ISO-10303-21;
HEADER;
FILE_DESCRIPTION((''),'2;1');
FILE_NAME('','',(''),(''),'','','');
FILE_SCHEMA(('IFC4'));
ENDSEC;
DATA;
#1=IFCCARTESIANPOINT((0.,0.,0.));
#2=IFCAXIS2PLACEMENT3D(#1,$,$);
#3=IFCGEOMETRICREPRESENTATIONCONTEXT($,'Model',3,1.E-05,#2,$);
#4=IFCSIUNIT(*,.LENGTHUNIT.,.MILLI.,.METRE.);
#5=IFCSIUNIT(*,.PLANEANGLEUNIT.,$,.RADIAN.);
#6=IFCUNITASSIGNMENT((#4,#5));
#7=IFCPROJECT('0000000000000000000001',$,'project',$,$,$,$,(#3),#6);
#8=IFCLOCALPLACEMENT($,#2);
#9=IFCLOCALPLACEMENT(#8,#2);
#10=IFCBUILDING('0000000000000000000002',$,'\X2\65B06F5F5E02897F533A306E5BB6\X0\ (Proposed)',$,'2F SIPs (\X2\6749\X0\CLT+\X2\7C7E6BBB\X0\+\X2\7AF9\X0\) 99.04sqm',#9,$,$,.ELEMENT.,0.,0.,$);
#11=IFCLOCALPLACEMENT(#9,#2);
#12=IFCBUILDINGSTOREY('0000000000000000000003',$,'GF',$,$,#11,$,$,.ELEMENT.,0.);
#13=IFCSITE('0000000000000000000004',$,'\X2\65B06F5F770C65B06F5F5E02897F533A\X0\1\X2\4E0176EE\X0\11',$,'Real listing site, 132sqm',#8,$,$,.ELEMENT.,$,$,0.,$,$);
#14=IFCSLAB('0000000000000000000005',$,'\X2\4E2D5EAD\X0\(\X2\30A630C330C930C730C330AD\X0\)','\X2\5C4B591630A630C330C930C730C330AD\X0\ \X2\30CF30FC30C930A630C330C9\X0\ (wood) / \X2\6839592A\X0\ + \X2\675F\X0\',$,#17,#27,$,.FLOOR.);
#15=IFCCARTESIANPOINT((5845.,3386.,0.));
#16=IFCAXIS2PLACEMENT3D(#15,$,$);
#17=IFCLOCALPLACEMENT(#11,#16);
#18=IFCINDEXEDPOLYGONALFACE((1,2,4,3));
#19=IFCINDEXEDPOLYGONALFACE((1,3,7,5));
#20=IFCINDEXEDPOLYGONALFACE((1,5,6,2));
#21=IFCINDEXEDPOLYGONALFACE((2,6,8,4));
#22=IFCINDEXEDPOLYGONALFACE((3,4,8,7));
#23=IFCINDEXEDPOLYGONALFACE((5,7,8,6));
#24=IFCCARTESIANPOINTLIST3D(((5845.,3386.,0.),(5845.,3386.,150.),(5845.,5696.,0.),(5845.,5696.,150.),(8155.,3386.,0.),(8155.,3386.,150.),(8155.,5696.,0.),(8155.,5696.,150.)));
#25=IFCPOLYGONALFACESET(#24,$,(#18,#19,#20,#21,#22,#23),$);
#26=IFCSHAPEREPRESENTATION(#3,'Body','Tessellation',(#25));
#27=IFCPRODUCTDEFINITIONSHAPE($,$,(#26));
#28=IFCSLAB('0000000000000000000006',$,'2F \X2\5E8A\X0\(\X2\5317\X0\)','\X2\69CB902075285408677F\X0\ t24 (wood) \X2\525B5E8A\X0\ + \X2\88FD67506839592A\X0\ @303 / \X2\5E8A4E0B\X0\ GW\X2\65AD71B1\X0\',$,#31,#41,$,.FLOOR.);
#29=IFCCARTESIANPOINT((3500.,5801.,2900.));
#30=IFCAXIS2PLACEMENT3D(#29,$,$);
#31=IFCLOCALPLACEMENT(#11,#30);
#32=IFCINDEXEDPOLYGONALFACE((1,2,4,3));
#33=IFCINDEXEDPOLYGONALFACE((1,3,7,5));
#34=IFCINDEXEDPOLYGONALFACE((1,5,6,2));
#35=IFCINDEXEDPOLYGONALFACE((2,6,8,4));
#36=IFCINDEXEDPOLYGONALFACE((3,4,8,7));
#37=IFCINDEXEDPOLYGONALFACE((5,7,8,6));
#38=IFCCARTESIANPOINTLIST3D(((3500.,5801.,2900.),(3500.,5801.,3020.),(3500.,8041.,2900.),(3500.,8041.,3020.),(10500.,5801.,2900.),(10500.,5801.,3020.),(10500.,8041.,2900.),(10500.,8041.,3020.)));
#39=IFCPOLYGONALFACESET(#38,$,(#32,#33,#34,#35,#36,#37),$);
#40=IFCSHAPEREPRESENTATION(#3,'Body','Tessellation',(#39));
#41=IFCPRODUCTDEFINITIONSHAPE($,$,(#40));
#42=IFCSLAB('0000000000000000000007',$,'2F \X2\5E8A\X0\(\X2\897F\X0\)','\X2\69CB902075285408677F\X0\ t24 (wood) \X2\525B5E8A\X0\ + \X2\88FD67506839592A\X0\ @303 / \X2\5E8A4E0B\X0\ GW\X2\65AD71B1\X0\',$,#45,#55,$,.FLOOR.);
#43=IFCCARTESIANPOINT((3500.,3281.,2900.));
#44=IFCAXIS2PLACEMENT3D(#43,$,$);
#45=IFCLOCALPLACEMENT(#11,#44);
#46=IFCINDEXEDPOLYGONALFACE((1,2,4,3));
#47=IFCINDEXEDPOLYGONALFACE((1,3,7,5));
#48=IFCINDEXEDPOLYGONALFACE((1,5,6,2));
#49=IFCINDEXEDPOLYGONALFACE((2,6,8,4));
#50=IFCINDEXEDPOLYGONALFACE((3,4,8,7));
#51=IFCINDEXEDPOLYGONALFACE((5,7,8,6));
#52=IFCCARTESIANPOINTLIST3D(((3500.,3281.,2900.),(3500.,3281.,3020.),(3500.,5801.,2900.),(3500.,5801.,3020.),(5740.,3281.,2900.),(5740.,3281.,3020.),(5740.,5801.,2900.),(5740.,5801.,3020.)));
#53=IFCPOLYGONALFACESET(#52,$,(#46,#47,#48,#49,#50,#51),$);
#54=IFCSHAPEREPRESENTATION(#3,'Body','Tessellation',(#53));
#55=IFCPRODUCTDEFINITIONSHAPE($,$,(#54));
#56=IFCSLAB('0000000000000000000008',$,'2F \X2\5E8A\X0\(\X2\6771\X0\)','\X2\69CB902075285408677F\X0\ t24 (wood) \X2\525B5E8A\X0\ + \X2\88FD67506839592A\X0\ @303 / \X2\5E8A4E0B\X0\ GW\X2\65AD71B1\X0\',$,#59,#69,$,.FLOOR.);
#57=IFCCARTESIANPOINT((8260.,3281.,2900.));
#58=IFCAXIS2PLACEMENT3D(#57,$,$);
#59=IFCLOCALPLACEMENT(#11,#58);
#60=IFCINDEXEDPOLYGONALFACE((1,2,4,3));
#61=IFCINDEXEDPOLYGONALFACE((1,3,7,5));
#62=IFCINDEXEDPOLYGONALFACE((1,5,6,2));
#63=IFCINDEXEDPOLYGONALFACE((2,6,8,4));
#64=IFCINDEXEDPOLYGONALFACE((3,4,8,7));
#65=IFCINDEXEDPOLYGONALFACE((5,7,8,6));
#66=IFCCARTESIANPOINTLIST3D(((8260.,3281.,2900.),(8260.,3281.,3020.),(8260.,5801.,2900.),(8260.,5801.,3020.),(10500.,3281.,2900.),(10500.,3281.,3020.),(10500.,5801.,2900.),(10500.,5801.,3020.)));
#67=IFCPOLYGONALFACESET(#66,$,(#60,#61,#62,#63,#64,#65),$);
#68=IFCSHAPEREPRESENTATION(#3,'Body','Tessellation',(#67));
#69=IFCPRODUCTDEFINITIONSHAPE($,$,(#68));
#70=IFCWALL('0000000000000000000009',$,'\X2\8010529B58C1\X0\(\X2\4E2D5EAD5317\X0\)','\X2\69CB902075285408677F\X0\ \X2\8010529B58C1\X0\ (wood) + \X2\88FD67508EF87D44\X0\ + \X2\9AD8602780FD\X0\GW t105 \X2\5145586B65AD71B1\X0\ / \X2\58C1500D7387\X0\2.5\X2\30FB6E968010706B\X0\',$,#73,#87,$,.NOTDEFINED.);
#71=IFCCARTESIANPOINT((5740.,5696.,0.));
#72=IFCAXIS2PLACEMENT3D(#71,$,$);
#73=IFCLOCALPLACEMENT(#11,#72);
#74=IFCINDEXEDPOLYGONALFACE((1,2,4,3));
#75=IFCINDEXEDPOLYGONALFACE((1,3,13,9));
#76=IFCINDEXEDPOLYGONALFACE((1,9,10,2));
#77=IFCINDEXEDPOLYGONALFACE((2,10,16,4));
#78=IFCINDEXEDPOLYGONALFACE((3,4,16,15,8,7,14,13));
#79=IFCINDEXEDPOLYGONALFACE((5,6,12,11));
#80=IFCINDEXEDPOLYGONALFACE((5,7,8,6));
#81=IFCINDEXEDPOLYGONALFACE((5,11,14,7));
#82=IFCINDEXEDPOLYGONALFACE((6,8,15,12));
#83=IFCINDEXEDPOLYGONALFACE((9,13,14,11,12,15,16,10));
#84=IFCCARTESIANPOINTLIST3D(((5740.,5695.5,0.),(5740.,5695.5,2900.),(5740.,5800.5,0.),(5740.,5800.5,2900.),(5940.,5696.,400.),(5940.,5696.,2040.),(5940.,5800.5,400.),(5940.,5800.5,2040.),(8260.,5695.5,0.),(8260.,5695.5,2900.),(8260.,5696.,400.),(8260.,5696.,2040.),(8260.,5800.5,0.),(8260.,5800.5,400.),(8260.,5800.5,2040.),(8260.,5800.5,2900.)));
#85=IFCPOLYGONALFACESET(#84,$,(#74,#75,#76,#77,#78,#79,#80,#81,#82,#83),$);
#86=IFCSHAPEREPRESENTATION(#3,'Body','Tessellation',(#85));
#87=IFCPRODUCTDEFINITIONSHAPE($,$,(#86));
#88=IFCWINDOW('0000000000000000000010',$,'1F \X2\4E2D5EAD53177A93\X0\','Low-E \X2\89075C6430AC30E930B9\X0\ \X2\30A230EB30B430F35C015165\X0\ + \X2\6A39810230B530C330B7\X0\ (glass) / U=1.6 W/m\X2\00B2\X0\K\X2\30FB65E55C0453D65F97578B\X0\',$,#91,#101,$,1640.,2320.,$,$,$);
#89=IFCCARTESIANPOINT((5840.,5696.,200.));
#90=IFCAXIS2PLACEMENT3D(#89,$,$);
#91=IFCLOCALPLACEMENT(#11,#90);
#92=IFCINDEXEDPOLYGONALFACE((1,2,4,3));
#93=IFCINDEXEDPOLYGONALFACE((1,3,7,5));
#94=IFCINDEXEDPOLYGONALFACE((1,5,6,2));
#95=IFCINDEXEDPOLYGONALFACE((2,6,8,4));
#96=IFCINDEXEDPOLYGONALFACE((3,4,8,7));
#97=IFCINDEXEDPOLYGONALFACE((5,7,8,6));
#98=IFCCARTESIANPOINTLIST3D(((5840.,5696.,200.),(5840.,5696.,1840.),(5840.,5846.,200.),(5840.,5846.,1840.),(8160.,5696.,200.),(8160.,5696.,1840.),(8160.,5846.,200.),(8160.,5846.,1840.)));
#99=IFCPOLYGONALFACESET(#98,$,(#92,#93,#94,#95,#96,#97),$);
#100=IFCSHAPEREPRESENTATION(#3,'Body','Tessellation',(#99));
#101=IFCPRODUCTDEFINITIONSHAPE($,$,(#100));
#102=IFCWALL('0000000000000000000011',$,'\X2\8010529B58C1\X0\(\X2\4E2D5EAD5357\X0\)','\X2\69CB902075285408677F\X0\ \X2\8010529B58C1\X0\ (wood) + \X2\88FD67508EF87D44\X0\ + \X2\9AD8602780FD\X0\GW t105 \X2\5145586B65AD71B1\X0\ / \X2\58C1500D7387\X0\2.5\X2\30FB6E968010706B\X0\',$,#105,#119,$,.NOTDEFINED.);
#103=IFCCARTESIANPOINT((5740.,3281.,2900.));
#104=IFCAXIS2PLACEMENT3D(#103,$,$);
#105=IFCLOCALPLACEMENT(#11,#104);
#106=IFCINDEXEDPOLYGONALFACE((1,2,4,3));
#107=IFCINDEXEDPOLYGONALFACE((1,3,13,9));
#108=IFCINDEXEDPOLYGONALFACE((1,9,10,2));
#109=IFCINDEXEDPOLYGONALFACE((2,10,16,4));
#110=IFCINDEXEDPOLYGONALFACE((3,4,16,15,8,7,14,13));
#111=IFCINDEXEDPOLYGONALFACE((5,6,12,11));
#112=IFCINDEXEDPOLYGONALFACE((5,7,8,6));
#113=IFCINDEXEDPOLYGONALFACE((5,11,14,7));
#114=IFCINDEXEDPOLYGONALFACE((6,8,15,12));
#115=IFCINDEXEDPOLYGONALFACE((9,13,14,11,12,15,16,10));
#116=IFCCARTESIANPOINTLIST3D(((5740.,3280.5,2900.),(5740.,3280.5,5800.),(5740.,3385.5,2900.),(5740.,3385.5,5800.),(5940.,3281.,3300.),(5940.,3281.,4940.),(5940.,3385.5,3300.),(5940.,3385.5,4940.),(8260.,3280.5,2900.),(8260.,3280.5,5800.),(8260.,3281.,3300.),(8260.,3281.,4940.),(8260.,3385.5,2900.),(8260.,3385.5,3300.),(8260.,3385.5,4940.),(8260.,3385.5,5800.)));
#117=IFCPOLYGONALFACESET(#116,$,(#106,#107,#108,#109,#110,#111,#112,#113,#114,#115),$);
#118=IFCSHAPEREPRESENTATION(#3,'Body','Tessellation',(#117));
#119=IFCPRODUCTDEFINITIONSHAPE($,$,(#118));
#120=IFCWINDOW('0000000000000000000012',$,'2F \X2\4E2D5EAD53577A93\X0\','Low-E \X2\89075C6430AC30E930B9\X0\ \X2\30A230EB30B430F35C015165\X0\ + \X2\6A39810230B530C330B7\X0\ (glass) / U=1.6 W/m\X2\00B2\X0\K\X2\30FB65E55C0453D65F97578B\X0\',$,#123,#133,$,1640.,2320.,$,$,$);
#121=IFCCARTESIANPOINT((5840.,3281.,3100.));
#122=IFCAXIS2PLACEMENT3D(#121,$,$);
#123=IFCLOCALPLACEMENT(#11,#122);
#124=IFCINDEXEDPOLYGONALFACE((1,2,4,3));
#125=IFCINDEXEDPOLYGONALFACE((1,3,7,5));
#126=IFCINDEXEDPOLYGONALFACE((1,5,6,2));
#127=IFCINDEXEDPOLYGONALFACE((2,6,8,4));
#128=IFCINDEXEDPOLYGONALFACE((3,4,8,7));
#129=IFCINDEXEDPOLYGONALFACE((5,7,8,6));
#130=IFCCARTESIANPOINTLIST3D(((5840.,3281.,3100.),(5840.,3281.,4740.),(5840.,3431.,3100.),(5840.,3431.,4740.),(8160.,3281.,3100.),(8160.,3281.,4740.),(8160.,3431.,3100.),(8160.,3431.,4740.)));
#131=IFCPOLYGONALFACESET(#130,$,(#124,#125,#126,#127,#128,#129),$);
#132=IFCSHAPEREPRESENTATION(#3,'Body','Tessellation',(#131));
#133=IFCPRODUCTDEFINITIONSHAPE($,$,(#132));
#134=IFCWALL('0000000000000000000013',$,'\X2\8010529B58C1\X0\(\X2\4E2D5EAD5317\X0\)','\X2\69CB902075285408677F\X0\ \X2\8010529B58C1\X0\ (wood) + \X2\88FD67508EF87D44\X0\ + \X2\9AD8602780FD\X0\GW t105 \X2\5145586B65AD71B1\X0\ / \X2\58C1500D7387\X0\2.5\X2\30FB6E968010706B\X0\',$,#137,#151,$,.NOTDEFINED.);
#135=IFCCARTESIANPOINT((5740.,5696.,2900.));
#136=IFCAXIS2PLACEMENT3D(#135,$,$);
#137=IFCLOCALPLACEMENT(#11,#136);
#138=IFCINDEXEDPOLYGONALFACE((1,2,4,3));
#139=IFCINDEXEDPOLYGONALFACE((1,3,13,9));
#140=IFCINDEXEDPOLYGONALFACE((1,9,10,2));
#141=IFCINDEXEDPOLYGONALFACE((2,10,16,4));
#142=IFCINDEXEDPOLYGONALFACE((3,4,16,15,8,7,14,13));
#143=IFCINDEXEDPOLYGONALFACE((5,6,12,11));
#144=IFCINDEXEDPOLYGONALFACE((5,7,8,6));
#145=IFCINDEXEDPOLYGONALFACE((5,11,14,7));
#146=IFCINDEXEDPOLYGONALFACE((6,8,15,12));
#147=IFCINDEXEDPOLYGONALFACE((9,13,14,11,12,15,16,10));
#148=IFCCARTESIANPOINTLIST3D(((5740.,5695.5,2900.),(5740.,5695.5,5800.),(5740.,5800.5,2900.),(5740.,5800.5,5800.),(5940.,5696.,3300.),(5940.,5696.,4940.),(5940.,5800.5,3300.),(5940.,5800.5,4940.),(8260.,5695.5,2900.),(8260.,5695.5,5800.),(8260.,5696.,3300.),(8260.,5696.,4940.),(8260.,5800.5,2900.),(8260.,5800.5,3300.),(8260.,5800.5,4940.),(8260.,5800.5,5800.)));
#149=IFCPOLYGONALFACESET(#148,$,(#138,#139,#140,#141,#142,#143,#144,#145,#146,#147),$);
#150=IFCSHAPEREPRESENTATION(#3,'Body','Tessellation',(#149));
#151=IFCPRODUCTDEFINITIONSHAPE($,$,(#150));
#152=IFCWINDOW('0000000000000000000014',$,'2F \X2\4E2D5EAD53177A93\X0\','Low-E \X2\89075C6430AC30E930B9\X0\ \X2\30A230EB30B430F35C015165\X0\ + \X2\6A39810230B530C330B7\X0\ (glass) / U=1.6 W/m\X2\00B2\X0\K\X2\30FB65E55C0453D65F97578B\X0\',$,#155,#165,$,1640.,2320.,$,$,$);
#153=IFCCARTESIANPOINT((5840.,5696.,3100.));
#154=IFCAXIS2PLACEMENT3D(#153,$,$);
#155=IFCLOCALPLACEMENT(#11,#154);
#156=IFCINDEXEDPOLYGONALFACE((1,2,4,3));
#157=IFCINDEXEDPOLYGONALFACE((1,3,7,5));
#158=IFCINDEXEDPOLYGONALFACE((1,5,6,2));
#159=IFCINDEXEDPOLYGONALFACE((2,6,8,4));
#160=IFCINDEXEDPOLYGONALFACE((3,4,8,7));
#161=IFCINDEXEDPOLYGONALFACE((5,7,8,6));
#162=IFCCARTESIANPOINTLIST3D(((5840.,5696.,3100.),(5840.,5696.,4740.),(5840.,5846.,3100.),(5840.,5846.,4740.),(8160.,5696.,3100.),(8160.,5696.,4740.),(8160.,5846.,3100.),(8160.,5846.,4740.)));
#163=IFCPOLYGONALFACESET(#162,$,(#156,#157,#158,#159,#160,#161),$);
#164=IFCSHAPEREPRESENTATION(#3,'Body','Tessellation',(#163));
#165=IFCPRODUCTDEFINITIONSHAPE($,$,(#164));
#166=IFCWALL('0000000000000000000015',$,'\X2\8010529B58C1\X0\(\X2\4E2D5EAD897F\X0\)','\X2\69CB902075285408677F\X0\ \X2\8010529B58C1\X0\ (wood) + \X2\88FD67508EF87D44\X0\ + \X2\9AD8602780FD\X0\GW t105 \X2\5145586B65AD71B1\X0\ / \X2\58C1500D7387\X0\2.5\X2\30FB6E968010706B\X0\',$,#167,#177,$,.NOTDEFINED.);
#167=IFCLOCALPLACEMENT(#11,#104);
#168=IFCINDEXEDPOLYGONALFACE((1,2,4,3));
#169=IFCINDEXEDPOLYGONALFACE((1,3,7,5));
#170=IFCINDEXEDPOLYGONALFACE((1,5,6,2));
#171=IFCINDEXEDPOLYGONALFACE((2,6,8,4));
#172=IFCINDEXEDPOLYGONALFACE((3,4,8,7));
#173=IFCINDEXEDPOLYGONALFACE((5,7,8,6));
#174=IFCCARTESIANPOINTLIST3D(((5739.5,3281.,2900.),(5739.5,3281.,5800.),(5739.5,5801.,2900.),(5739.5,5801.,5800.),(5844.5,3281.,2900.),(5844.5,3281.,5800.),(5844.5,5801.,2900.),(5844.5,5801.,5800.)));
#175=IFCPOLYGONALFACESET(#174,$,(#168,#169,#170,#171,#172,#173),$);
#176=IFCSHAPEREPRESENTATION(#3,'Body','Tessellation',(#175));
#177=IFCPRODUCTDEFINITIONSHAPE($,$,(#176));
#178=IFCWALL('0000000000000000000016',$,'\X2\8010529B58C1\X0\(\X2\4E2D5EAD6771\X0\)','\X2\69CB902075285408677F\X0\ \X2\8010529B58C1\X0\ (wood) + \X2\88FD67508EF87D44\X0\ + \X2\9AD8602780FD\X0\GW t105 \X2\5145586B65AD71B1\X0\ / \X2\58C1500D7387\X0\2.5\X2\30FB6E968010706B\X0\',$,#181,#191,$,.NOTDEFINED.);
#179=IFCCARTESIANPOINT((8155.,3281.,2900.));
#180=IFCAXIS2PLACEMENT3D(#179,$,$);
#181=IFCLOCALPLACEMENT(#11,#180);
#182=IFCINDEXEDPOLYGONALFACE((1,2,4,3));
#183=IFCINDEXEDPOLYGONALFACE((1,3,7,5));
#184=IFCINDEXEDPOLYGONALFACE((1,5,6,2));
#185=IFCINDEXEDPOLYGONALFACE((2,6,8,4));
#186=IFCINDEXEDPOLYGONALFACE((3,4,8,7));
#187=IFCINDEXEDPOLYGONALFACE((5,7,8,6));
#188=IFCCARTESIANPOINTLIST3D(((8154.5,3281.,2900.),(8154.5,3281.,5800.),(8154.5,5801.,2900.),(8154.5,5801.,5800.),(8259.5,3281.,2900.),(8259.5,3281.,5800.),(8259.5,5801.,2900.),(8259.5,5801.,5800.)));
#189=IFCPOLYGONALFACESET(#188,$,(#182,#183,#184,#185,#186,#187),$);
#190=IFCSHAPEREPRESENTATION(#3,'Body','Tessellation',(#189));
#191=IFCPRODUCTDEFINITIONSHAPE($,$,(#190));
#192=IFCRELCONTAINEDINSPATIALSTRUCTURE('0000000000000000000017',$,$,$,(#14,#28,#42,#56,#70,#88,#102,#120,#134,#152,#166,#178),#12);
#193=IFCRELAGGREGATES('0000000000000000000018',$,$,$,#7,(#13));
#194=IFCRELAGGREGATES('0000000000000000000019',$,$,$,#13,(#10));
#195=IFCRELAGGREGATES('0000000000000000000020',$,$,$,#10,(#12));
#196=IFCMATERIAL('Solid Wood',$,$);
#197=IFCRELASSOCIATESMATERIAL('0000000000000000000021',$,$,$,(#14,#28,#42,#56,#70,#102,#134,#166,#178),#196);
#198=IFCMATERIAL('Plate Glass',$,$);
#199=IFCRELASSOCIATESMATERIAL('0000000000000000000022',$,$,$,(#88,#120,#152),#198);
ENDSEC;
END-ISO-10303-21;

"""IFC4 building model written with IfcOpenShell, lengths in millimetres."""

from ifc_helpers import new_model, si_unit, frame, frame_2d, origin, place, context, project, spatial, rectangle, extrude, material, element, fill, save


model = new_model("IFC4")

# Units and contexts
model_context = context("Model", 3, precision=1e-05, world=origin())
ifc_project = project(units=[si_unit("LENGTHUNIT", "METRE", prefix="MILLI"), si_unit("PLANEANGLEUNIT", "RADIAN")], contexts=[model_context])

# Site, building, storey
site_placement = place(None, origin())
site = spatial("IfcSite", under=ifc_project, at=site_placement, Name="新潟県新潟市西区1丁目11", ObjectType="Real listing site, 132sqm", CompositionType="ELEMENT", RefElevation=0.0)
building_placement = place(site_placement, origin())
building = spatial("IfcBuilding", under=site, at=building_placement, Name="新潟市西区の家 (Proposed)", ObjectType="2F SIPs (杉CLT+籾殻+竹) 99.04sqm", CompositionType="ELEMENT", ElevationOfRefHeight=0.0, ElevationOfTerrain=0.0)
storey_placement = place(building_placement, origin())
storey = spatial("IfcBuildingStorey", under=building, at=storey_placement, Name="GF", CompositionType="ELEMENT", Elevation=0.0)

# Slabs
ifc_material_1 = material(Name="Solid Wood")
slab_1_placement = place(storey_placement, frame((5845.0, 3386.0, 0.0)))
element("IfcSlab", 1, at=slab_1_placement, inside=storey, material=ifc_material_1, Name="中庭(ウッドデッキ)", Description="屋外ウッドデッキ ハードウッド (wood) / 根太 + 束", PredefinedType="FLOOR", context=model_context, shape_type="SweptSolid", body=[
    extrude(rectangle(XDim=2310.0, YDim=2310.0, at=frame_2d((1155.0, 1155.0))), frame((5845.0, 3386.0, 0.0)), (0.0, 0.0, 1.0), 150.0),
])
slab_2_placement = place(storey_placement, frame((3500.0, 5801.0, 2900.0)))
element("IfcSlab", 2, at=slab_2_placement, inside=storey, material=ifc_material_1, Name="2F 床(北)", Description="構造用合板 t24 (wood) 剛床 + 製材根太 @303 / 床下 GW断熱", PredefinedType="FLOOR", context=model_context, shape_type="SweptSolid", body=[
    extrude(rectangle(XDim=7000.0, YDim=2240.0, at=frame_2d((3500.0, 1120.0))), frame((3500.0, 5801.0, 2900.0)), (0.0, 0.0, 1.0), 120.0),
])
slab_3_placement = place(storey_placement, frame((3500.0, 3281.0, 2900.0)))
element("IfcSlab", 3, at=slab_3_placement, inside=storey, material=ifc_material_1, Name="2F 床(西)", Description="構造用合板 t24 (wood) 剛床 + 製材根太 @303 / 床下 GW断熱", PredefinedType="FLOOR", context=model_context, shape_type="SweptSolid", body=[
    extrude(rectangle(XDim=2240.0, YDim=2520.0, at=frame_2d((1120.0, 1260.0))), frame((3500.0, 3281.0, 2900.0)), (0.0, 0.0, 1.0), 120.0),
])
slab_4_placement = place(storey_placement, frame((8260.0, 3281.0, 2900.0)))
element("IfcSlab", 4, at=slab_4_placement, inside=storey, material=ifc_material_1, Name="2F 床(東)", Description="構造用合板 t24 (wood) 剛床 + 製材根太 @303 / 床下 GW断熱", PredefinedType="FLOOR", context=model_context, shape_type="SweptSolid", body=[
    extrude(rectangle(XDim=2240.0, YDim=2520.0, at=frame_2d((1120.0, 1260.0))), frame((8260.0, 3281.0, 2900.0)), (0.0, 0.0, 1.0), 120.0),
])

# Wall, opening, window
wall_1_placement = place(storey_placement, frame((5740.0, 5696.0, 0.0)))
wall_1 = element("IfcWall", 5, at=wall_1_placement, inside=storey, material=ifc_material_1, Name="耐力壁(中庭北)", Description="構造用合板 耐力壁 (wood) + 製材軸組 + 高性能GW t105 充填断熱 / 壁倍率2.5・準耐火", PredefinedType="NOTDEFINED", context=model_context, shape_type="SweptSolid", body=[
    extrude(rectangle(XDim=2520.0, YDim=105.0, at=frame_2d((1260.0, 52.0))), frame((5740.0, 5696.0, 0.0)), (0.0, 0.0, 1.0), 2900.0),
])
opening_1_placement = place(storey_placement, frame((5840.0, 5696.0, 200.0)))
opening_1 = element("IfcOpeningElement", 6, at=opening_1_placement, cuts=wall_1, PredefinedType="NOTDEFINED", context=model_context, shape_type="SweptSolid", body=[
    extrude(rectangle(XDim=2320.0, YDim=150.0, at=frame_2d((1160.0, 75.0))), frame((5840.0, 5696.0, 200.0)), (0.0, 0.0, 1.0), 1640.0),
])
ifc_material_2 = material(Name="Plate Glass")
window_1_placement = place(storey_placement, frame((5840.0, 5696.0, 200.0)))
window_1 = element("IfcWindow", 7, at=window_1_placement, inside=storey, material=ifc_material_2, Name="1F 中庭北窓", Description="Low-E 複層ガラス アルゴン封入 + 樹脂サッシ (glass) / U=1.6 W/m²K・日射取得型", OverallHeight=1640.0, OverallWidth=2320.0, context=model_context, shape_type="SweptSolid", body=[
    extrude(rectangle(XDim=2320.0, YDim=150.0, at=frame_2d((1160.0, 75.0))), frame((5840.0, 5696.0, 200.0)), (0.0, 0.0, 1.0), 1640.0),
])
fill(opening_1, window_1)

# Walls, openings, windows
wall_2_placement = place(storey_placement, frame((5740.0, 3281.0, 2900.0)))
wall_2 = element("IfcWall", 8, at=wall_2_placement, inside=storey, material=ifc_material_1, Name="耐力壁(中庭南)", Description="構造用合板 耐力壁 (wood) + 製材軸組 + 高性能GW t105 充填断熱 / 壁倍率2.5・準耐火", PredefinedType="NOTDEFINED", context=model_context, shape_type="SweptSolid", body=[
    extrude(rectangle(XDim=2520.0, YDim=105.0, at=frame_2d((1260.0, 52.0))), frame((5740.0, 3281.0, 2900.0)), (0.0, 0.0, 1.0), 2900.0),
])
opening_2_placement = place(storey_placement, frame((5840.0, 3281.0, 3100.0)))
opening_2 = element("IfcOpeningElement", 9, at=opening_2_placement, cuts=wall_2, PredefinedType="NOTDEFINED", context=model_context, shape_type="SweptSolid", body=[
    extrude(rectangle(XDim=2320.0, YDim=150.0, at=frame_2d((1160.0, 75.0))), frame((5840.0, 3281.0, 3100.0)), (0.0, 0.0, 1.0), 1640.0),
])
window_2_placement = place(storey_placement, frame((5840.0, 3281.0, 3100.0)))
window_2 = element("IfcWindow", 10, at=window_2_placement, inside=storey, material=ifc_material_2, Name="2F 中庭南窓", Description="Low-E 複層ガラス アルゴン封入 + 樹脂サッシ (glass) / U=1.6 W/m²K・日射取得型", OverallHeight=1640.0, OverallWidth=2320.0, context=model_context, shape_type="SweptSolid", body=[
    extrude(rectangle(XDim=2320.0, YDim=150.0, at=frame_2d((1160.0, 75.0))), frame((5840.0, 3281.0, 3100.0)), (0.0, 0.0, 1.0), 1640.0),
])
fill(opening_2, window_2)
wall_3_placement = place(storey_placement, frame((5740.0, 5696.0, 2900.0)))
wall_3 = element("IfcWall", 11, at=wall_3_placement, inside=storey, material=ifc_material_1, Name="耐力壁(中庭北)", Description="構造用合板 耐力壁 (wood) + 製材軸組 + 高性能GW t105 充填断熱 / 壁倍率2.5・準耐火", PredefinedType="NOTDEFINED", context=model_context, shape_type="SweptSolid", body=[
    extrude(rectangle(XDim=2520.0, YDim=105.0, at=frame_2d((1260.0, 52.0))), frame((5740.0, 5696.0, 2900.0)), (0.0, 0.0, 1.0), 2900.0),
])
opening_3_placement = place(storey_placement, frame((5840.0, 5696.0, 3100.0)))
opening_3 = element("IfcOpeningElement", 12, at=opening_3_placement, cuts=wall_3, PredefinedType="NOTDEFINED", context=model_context, shape_type="SweptSolid", body=[
    extrude(rectangle(XDim=2320.0, YDim=150.0, at=frame_2d((1160.0, 75.0))), frame((5840.0, 5696.0, 3100.0)), (0.0, 0.0, 1.0), 1640.0),
])
window_3_placement = place(storey_placement, frame((5840.0, 5696.0, 3100.0)))
window_3 = element("IfcWindow", 13, at=window_3_placement, inside=storey, material=ifc_material_2, Name="2F 中庭北窓", Description="Low-E 複層ガラス アルゴン封入 + 樹脂サッシ (glass) / U=1.6 W/m²K・日射取得型", OverallHeight=1640.0, OverallWidth=2320.0, context=model_context, shape_type="SweptSolid", body=[
    extrude(rectangle(XDim=2320.0, YDim=150.0, at=frame_2d((1160.0, 75.0))), frame((5840.0, 5696.0, 3100.0)), (0.0, 0.0, 1.0), 1640.0),
])
fill(opening_3, window_3)

# Walls
wall_4_placement = place(storey_placement, frame((5740.0, 3281.0, 2900.0)))
element("IfcWall", 14, at=wall_4_placement, inside=storey, material=ifc_material_1, Name="耐力壁(中庭西)", Description="構造用合板 耐力壁 (wood) + 製材軸組 + 高性能GW t105 充填断熱 / 壁倍率2.5・準耐火", PredefinedType="NOTDEFINED", context=model_context, shape_type="SweptSolid", body=[
    extrude(rectangle(XDim=105.0, YDim=2520.0, at=frame_2d((52.0, 1260.0))), frame((5740.0, 3281.0, 2900.0)), (0.0, 0.0, 1.0), 2900.0),
])
wall_5_placement = place(storey_placement, frame((8155.0, 3281.0, 2900.0)))
element("IfcWall", 15, at=wall_5_placement, inside=storey, material=ifc_material_1, Name="耐力壁(中庭東)", Description="構造用合板 耐力壁 (wood) + 製材軸組 + 高性能GW t105 充填断熱 / 壁倍率2.5・準耐火", PredefinedType="NOTDEFINED", context=model_context, shape_type="SweptSolid", body=[
    extrude(rectangle(XDim=105.0, YDim=2520.0, at=frame_2d((52.0, 1260.0))), frame((8155.0, 3281.0, 2900.0)), (0.0, 0.0, 1.0), 2900.0),
])

save(model, "model.ifc")
